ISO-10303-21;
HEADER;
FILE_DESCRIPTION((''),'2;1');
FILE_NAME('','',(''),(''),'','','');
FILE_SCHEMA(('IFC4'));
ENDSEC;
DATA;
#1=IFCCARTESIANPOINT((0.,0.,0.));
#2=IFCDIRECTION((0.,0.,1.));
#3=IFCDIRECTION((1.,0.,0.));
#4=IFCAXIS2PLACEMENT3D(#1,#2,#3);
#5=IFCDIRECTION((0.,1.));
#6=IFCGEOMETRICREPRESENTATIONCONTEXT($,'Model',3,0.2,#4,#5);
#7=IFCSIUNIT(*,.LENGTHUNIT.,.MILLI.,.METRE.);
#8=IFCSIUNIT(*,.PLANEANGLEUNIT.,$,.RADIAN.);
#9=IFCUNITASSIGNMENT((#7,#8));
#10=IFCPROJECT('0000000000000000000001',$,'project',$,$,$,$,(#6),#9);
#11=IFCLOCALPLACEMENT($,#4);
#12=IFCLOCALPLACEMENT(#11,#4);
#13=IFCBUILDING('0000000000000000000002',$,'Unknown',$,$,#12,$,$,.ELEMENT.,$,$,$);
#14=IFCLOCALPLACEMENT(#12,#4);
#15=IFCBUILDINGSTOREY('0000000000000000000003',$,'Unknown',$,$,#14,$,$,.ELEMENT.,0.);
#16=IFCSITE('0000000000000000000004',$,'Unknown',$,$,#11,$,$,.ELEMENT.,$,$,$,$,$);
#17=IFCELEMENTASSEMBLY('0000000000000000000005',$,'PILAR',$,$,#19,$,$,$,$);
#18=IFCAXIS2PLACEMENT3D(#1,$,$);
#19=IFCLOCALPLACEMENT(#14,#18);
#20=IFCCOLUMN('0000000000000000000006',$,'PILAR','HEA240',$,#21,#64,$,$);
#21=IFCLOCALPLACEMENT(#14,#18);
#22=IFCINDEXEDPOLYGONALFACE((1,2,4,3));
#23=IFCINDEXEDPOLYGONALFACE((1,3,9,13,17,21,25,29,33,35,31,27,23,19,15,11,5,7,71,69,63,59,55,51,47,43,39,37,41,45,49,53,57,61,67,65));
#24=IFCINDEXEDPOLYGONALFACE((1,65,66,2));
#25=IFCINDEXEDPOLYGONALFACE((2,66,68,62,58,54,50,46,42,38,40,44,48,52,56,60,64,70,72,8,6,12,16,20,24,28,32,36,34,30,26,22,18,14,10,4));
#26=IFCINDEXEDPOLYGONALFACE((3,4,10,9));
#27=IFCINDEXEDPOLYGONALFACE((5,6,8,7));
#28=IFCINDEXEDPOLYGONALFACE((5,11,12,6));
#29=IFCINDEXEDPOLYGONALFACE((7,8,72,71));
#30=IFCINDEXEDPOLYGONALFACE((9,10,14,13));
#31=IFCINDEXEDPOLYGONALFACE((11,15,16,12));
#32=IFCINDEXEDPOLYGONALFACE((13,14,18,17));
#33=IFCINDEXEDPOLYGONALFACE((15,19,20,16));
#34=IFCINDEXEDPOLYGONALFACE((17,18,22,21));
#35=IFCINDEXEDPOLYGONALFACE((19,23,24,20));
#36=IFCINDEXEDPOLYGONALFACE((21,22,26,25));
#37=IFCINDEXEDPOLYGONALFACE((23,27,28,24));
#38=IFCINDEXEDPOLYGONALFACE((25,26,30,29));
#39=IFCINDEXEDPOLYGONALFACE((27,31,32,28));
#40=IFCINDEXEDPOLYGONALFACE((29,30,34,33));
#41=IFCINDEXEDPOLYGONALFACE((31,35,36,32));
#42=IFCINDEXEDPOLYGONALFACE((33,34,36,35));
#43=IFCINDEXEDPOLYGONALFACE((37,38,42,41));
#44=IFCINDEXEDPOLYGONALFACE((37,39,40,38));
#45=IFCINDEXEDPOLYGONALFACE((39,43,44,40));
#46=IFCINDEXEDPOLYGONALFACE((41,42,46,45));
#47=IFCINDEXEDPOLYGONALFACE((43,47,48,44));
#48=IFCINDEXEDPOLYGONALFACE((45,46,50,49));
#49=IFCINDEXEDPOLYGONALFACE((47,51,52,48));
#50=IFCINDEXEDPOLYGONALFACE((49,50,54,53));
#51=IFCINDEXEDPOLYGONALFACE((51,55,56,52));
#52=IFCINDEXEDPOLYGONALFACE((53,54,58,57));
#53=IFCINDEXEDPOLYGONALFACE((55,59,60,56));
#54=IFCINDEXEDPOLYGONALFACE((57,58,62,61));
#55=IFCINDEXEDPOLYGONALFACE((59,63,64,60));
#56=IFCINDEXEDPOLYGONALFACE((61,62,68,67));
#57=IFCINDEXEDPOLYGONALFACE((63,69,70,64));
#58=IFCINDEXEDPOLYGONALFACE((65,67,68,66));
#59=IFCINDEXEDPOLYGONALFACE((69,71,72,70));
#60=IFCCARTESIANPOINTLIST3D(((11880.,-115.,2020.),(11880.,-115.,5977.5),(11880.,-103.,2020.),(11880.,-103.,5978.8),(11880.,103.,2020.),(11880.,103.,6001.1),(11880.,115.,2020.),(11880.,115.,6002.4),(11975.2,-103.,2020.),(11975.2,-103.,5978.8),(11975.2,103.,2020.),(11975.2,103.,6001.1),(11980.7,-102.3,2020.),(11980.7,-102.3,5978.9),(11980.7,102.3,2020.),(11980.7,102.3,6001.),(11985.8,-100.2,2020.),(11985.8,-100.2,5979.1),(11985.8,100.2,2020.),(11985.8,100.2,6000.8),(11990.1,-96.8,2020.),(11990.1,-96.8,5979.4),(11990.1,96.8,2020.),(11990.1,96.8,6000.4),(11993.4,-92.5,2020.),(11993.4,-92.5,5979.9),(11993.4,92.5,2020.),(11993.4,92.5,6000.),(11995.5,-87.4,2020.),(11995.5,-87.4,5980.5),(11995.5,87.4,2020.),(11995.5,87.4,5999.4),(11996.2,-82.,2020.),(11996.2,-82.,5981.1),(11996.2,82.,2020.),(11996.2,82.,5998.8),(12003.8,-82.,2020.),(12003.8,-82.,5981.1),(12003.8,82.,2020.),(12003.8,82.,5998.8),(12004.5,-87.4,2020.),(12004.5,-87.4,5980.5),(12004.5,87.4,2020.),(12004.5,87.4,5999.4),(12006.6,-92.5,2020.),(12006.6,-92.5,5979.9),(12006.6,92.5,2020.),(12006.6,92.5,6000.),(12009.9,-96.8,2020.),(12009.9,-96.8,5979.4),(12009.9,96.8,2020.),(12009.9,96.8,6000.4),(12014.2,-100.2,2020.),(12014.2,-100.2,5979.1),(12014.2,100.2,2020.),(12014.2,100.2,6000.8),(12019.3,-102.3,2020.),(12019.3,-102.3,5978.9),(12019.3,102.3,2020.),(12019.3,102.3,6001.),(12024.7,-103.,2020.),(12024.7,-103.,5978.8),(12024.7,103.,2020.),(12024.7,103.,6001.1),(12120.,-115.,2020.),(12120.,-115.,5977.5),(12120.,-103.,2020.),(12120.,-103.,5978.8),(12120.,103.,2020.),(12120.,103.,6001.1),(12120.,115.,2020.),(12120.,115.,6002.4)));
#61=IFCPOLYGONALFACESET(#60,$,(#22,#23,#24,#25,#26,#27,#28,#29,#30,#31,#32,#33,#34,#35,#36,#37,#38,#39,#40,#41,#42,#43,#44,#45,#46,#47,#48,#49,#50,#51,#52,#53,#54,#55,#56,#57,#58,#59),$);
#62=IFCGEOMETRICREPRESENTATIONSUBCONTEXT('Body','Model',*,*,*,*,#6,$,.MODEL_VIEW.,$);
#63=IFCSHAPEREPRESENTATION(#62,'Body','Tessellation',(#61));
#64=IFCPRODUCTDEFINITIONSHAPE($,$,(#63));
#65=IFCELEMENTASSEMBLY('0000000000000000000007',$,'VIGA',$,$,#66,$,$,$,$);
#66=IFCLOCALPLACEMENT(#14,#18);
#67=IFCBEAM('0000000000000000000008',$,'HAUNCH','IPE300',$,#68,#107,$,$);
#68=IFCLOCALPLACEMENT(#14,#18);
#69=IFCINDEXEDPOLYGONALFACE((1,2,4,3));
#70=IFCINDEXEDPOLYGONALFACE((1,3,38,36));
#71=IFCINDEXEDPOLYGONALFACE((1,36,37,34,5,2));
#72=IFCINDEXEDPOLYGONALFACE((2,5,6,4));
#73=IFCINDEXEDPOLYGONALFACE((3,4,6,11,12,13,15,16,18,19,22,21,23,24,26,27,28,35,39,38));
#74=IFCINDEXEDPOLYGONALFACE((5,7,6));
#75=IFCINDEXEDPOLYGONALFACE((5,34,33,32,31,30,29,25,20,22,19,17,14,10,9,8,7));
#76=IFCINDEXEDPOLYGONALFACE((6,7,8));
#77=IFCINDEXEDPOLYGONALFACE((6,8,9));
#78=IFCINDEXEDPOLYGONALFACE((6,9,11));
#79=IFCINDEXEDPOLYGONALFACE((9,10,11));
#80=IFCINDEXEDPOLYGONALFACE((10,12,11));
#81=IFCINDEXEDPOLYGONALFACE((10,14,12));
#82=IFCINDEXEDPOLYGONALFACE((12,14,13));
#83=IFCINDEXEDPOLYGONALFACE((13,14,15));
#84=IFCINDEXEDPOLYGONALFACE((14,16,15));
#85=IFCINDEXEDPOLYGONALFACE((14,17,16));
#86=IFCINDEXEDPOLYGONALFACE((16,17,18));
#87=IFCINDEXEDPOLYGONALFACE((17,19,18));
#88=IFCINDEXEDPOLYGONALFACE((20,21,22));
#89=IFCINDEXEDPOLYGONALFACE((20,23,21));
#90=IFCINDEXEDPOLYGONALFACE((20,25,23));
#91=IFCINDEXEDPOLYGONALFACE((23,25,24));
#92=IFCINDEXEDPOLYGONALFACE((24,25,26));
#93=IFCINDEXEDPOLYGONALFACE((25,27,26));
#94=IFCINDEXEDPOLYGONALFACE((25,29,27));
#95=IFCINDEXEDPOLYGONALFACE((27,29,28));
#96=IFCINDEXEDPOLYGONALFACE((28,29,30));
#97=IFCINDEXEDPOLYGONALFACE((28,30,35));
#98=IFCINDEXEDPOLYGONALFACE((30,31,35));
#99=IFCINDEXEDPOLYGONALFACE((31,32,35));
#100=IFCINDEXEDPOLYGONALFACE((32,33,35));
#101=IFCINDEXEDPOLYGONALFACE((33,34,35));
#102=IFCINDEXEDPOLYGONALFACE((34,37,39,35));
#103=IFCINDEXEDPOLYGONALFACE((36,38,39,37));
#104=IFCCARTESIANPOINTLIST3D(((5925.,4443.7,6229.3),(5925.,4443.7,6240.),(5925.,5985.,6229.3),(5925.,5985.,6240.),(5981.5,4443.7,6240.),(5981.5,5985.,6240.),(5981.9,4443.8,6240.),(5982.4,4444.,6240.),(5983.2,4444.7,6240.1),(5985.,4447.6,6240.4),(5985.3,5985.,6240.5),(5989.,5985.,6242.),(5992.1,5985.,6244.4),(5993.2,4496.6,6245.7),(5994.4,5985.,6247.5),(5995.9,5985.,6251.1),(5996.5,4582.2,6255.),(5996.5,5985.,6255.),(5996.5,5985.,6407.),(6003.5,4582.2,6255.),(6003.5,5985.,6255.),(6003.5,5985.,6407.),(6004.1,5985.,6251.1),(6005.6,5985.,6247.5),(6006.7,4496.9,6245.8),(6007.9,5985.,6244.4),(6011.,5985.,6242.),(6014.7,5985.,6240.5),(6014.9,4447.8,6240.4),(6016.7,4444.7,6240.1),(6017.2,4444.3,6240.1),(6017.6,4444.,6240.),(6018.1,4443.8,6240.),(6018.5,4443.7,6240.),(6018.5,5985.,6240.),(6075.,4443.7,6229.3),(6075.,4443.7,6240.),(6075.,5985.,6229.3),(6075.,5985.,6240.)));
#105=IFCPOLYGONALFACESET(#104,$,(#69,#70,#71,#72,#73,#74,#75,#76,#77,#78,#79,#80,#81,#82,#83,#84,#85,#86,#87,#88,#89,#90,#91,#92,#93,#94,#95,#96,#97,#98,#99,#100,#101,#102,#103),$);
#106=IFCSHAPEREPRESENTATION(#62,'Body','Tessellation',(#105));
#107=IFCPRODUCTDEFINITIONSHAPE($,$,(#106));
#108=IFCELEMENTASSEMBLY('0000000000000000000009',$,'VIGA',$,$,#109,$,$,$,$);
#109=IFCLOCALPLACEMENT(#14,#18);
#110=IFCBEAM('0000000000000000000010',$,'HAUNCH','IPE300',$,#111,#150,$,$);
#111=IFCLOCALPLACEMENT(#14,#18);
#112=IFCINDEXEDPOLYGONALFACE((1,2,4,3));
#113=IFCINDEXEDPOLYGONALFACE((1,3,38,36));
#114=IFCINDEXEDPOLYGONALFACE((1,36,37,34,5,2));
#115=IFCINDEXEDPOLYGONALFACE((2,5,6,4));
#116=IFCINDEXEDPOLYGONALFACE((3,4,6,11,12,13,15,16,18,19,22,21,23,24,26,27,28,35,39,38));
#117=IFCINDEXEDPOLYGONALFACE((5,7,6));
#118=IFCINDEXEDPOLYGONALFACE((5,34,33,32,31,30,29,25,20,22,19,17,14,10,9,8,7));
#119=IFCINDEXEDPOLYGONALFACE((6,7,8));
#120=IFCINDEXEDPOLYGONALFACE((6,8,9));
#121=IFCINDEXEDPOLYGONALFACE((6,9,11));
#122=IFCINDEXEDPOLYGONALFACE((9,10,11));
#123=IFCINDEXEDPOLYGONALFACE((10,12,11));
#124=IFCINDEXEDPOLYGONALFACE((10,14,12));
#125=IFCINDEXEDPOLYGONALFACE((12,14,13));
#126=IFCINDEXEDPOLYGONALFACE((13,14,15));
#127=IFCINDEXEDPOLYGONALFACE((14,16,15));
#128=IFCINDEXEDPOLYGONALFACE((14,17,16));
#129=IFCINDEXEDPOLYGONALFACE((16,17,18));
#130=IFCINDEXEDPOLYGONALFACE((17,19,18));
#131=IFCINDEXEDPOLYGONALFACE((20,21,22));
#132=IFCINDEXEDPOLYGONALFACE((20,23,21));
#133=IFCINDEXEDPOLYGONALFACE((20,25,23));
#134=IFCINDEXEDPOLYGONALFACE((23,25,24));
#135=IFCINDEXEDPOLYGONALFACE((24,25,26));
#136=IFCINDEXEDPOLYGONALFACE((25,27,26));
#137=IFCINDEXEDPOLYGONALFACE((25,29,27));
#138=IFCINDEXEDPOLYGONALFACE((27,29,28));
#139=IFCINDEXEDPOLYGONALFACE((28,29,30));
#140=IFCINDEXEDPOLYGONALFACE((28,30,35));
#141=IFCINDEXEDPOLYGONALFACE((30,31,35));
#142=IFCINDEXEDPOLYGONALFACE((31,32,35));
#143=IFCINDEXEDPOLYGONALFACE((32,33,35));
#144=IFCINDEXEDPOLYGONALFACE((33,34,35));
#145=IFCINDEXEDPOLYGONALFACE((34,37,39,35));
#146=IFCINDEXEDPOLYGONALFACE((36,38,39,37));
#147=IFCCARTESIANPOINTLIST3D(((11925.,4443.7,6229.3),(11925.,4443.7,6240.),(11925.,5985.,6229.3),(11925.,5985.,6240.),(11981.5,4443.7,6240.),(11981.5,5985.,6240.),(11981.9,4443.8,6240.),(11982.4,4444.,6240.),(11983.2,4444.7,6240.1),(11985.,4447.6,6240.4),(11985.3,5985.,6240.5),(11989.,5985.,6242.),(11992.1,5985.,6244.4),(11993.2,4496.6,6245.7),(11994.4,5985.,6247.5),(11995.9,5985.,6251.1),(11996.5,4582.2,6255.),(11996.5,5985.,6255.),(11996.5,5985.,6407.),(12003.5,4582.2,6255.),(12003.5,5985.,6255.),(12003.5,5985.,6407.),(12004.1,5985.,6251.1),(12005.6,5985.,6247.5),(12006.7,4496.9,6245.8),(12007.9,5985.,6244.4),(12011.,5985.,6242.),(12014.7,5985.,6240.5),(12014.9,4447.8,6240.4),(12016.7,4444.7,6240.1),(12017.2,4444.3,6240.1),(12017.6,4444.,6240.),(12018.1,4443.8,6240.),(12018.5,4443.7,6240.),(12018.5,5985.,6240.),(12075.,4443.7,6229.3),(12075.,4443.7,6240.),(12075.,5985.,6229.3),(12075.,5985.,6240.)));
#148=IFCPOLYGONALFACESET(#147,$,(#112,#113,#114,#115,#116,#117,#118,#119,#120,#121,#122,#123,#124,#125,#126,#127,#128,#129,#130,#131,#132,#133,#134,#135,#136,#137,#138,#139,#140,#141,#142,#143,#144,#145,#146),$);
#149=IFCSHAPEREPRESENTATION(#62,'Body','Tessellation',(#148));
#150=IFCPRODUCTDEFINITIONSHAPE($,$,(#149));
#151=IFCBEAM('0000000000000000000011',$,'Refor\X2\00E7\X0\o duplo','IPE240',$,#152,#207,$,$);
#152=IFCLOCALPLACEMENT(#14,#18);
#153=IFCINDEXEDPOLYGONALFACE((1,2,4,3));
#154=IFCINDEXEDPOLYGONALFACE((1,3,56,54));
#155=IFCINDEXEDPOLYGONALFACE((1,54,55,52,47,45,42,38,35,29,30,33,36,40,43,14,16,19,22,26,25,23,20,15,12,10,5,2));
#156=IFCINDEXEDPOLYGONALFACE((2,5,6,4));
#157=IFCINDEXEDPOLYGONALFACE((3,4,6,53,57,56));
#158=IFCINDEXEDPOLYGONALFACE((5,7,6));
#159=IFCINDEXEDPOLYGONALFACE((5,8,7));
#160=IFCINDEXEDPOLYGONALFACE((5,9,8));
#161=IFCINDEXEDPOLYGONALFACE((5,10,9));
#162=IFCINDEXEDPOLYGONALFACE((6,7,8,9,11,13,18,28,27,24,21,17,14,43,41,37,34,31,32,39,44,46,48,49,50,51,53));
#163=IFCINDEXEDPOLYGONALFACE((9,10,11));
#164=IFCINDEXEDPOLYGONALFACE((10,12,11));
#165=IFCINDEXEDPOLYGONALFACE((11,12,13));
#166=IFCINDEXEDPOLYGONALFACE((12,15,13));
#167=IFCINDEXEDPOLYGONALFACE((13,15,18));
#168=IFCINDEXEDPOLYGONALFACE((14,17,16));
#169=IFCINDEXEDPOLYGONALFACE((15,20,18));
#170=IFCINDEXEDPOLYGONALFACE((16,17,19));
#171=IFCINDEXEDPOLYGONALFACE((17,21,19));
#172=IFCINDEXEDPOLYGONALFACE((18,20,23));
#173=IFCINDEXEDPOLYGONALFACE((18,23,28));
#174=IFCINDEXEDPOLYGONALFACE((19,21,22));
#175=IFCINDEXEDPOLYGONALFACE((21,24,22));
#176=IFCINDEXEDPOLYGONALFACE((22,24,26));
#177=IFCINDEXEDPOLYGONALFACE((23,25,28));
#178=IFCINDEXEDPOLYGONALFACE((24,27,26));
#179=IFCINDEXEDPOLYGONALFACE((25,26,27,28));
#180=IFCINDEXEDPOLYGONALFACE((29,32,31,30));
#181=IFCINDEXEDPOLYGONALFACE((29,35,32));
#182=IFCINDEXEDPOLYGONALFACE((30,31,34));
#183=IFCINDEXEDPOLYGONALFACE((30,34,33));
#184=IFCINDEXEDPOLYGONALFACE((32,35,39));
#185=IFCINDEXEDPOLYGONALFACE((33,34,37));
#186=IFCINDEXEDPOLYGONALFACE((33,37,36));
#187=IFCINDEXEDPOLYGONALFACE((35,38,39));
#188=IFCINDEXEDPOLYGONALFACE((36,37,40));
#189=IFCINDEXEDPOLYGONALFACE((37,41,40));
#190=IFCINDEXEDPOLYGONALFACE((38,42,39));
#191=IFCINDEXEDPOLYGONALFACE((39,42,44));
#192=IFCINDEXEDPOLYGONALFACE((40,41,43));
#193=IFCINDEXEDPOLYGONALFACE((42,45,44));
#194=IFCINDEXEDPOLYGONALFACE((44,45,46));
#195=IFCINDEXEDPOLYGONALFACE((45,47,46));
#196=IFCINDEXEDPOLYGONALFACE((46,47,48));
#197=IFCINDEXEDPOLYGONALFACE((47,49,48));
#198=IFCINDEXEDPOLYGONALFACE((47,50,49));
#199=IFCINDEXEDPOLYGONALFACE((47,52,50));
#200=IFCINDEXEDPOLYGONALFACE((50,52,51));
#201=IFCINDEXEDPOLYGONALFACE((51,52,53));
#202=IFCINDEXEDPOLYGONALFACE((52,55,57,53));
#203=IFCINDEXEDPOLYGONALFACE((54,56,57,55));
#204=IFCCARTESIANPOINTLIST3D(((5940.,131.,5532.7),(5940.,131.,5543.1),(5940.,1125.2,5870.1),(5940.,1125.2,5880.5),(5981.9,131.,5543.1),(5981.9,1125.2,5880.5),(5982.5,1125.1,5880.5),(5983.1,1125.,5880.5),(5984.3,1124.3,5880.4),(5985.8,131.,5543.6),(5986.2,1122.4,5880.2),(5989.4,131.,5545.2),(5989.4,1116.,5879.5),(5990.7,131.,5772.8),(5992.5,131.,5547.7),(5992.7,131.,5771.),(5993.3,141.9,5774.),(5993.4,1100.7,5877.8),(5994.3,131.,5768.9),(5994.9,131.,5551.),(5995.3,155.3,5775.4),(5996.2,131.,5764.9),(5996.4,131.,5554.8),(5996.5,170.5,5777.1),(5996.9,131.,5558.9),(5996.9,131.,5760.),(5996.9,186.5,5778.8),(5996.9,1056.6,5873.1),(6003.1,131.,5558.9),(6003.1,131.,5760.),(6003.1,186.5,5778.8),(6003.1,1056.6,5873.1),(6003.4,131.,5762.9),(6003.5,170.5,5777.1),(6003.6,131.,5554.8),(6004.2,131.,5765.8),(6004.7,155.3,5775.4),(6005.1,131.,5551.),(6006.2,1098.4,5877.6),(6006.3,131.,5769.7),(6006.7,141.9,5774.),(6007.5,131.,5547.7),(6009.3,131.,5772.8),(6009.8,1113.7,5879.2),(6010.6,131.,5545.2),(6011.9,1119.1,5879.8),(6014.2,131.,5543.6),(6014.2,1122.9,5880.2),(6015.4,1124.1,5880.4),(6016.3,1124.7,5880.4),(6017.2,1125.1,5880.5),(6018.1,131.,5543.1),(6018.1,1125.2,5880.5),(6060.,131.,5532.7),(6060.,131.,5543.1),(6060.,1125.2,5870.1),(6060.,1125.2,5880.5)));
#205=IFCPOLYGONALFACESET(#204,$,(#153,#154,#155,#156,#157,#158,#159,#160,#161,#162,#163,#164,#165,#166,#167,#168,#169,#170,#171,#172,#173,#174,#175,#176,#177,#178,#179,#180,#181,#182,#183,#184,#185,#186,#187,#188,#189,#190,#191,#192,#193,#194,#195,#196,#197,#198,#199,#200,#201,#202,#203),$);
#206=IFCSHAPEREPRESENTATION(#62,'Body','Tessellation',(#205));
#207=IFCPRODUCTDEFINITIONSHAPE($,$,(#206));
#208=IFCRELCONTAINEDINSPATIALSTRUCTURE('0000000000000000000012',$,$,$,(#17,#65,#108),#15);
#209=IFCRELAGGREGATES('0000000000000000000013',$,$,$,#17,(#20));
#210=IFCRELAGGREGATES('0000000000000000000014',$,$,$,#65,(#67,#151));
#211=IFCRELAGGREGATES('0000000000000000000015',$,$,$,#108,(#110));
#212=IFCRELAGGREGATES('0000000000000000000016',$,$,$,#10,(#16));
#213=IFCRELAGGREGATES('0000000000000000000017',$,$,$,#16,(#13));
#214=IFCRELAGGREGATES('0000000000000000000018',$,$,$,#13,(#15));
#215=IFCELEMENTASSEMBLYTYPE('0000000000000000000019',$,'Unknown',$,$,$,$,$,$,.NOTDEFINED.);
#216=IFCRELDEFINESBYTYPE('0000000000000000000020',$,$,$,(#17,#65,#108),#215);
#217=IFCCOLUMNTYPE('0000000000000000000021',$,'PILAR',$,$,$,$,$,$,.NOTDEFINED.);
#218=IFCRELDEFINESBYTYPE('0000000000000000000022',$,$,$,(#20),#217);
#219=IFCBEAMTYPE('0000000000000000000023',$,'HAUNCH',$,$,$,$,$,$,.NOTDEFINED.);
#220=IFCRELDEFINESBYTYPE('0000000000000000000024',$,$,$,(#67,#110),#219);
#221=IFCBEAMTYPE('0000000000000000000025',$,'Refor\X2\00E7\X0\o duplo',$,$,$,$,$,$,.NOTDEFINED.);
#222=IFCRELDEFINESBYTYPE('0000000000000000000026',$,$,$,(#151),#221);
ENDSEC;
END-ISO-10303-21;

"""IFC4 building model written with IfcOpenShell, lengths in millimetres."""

from ifc_helpers import new_model, si_unit, direction, frame, origin_with_axes, origin_2d_with_axis, place, context, subcontext, project, spatial, i_section, extrude, clip, halfspace, type_object, element, aggregate, save


model = new_model("IFC4")

# Units and contexts
model_context = context("Model", 3, precision=0.2, world=origin_with_axes(), true_north=direction((0.0, 1.0)))
body_context = subcontext(model_context, "Body", "Model", "MODEL_VIEW")
ifc_project = project(units=[si_unit("LENGTHUNIT", "METRE", prefix="MILLI"), si_unit("PLANEANGLEUNIT", "RADIAN")], contexts=[model_context])

# Site, building, storey
site_placement = place(None, origin_with_axes())
site = spatial("IfcSite", under=ifc_project, at=site_placement, Name="Unknown", CompositionType="ELEMENT")
building_placement = place(site_placement, origin_with_axes())
building = spatial("IfcBuilding", under=site, at=building_placement, Name="Unknown", CompositionType="ELEMENT")
storey_placement = place(building_placement, origin_with_axes())
storey = spatial("IfcBuildingStorey", under=building, at=storey_placement, Name="Unknown", CompositionType="ELEMENT", Elevation=0.0)

# Element assembly, column
element_assembly_type = type_object("IfcElementAssemblyType", Name="Unknown", PredefinedType="NOTDEFINED")
assembly_1_placement = place(storey_placement, frame((12000.0, 0.0, 2000.0), z_axis=(1.0, 0.0, 0.0), x_axis=(0.0, 0.0, 1.0)))
assembly_1 = element("IfcElementAssembly", 1, at=assembly_1_placement, inside=storey, type_object=element_assembly_type, Name="PILAR")
column_type = type_object("IfcColumnType", Name="PILAR", PredefinedType="NOTDEFINED")
column_placement = place(assembly_1_placement, origin_with_axes())
column = element("IfcColumn", 2, at=column_placement, type_object=column_type, Name="PILAR", Description="HEA240", context=body_context, shape_type="Clipping", body=[
    clip(clip(extrude(i_section(OverallWidth=240.0, OverallDepth=230.0, WebThickness=7.5, FlangeThickness=12.0, FilletRadius=21.0, FlangeEdgeRadius=0.0, FlangeSlope=0.0, at=origin_2d_with_axis()), frame((-220.0, 0.0, 0.0), z_axis=(-1.0, 0.0, 0.0), x_axis=(0.0, 0.0, 1.0)), (0.0, 0.0, -1.0), 4449.9), halfspace(frame((20.0, -115.0, 0.0), z_axis=(1.0, 0.0, 0.0), x_axis=(0.0, 1.0, 0.0)), True)), halfspace(frame((3977.5, 115.0, 0.0), z_axis=(-0.994183, -0.107703, 0.0), x_axis=(0.107703, -0.994183, 0.0)), True)),
])

# Element assemblies, beams
assembly_2_placement = place(storey_placement, frame((6000.0, 12.9, 5880.7), z_axis=(1.0, 0.0, 0.0), x_axis=(0.0, 0.994183, 0.107703)))
assembly_2 = element("IfcElementAssembly", 3, at=assembly_2_placement, inside=storey, type_object=element_assembly_type, Name="VIGA")
beam_type_1 = type_object("IfcBeamType", Name="HAUNCH", PredefinedType="NOTDEFINED")
beam_1_placement = place(assembly_2_placement, frame((5991.0, -147.5, 0.0), z_axis=(0.0, 0.0, -1.0), x_axis=(-0.994183, 0.107703, 0.0)))
beam_1 = element("IfcBeam", 4, at=beam_1_placement, type_object=beam_type_1, Name="HAUNCH", Description="IPE300", context=body_context, shape_type="Clipping", body=[
    clip(clip(clip(extrude(i_section(OverallWidth=150.0, OverallDepth=300.0, WebThickness=7.1, FlangeThickness=10.7, FilletRadius=15.0, FlangeEdgeRadius=0.0, FlangeSlope=0.0, at=origin_2d_with_axis()), frame((-300.0, 0.0, 0.0), z_axis=(-1.0, 0.0, 0.0), x_axis=(0.0, 0.0, 1.0)), (0.0, 0.0, -1.0), 2141.3), halfspace(frame((0.0, 27.7, 0.0), z_axis=(-1.0, 0.0, 0.0), x_axis=(0.0, -1.0, 0.0)), False)), halfspace(frame((-1129.2, 150.0, -75.0), z_axis=(0.107703, 0.994183, 0.0), x_axis=(0.0, 0.0, 1.0)), False)), halfspace(frame((1541.3, -139.3, 0.0), z_axis=(-1.0, 0.0, 0.0), x_axis=(0.0, -1.0, 0.0)), True)),
])
assembly_3_placement = place(storey_placement, frame((12000.0, 12.9, 5880.7), z_axis=(1.0, 0.0, 0.0), x_axis=(0.0, 0.994183, 0.107703)))
assembly_3 = element("IfcElementAssembly", 5, at=assembly_3_placement, inside=storey, type_object=element_assembly_type, Name="VIGA")
beam_2_placement = place(assembly_3_placement, frame((5991.0, -147.5, 0.0), z_axis=(0.0, 0.0, -1.0), x_axis=(-0.994183, 0.107703, 0.0)))
beam_2 = element("IfcBeam", 6, at=beam_2_placement, type_object=beam_type_1, Name="HAUNCH", Description="IPE300", context=body_context, shape_type="Clipping", body=[
    clip(clip(clip(extrude(i_section(OverallWidth=150.0, OverallDepth=300.0, WebThickness=7.1, FlangeThickness=10.7, FilletRadius=15.0, FlangeEdgeRadius=0.0, FlangeSlope=0.0, at=origin_2d_with_axis()), frame((-300.0, 0.0, 0.0), z_axis=(-1.0, 0.0, 0.0), x_axis=(0.0, 0.0, 1.0)), (0.0, 0.0, -1.0), 2141.3), halfspace(frame((0.0, 27.7, 0.0), z_axis=(-1.0, 0.0, 0.0), x_axis=(0.0, -1.0, 0.0)), False)), halfspace(frame((-1129.2, 150.0, -75.0), z_axis=(0.107703, 0.994183, 0.0), x_axis=(0.0, 0.0, 1.0)), False)), halfspace(frame((1541.3, -139.3, 0.0), z_axis=(-1.0, 0.0, 0.0), x_axis=(0.0, -1.0, 0.0)), True)),
])

# Beam
beam_type_2 = type_object("IfcBeamType", Name="Reforço duplo", PredefinedType="NOTDEFINED")
beam_3_placement = place(assembly_2_placement, frame((53.8, -241.6, 0.0), z_axis=(0.0, 0.0, 1.0), x_axis=(0.976051, 0.217543, 0.0)))
beam_3 = element("IfcBeam", 7, at=beam_3_placement, type_object=beam_type_2, Name="Reforço duplo", Description="IPE240", context=body_context, shape_type="Clipping", body=[
    clip(clip(clip(extrude(i_section(OverallWidth=120.0, OverallDepth=240.0, WebThickness=6.2, FlangeThickness=9.8, FilletRadius=15.0, FlangeEdgeRadius=0.0, FlangeSlope=0.0, at=origin_2d_with_axis()), frame((-199.3, 0.0, 0.0), z_axis=(-1.0, 0.0, 0.0), x_axis=(0.0, 0.0, 1.0)), (0.0, 0.0, -1.0), 1529.9), halfspace(frame((476.2, 1282.9, 0.0), z_axis=(-0.946943, 0.321401, 0.0), x_axis=(-0.321401, -0.946943, 0.0)), False)), halfspace(frame((20.4, 120.0, -60.0), z_axis=(0.217543, 0.976051, 0.0), x_axis=(0.0, 0.0, 1.0)), False)), halfspace(frame((1049.9, -120.0, 0.0), z_axis=(0.946943, -0.321401, 0.0), x_axis=(0.321401, 0.946943, 0.0)), False)),
])

aggregate(assembly_1, [column])
aggregate(assembly_2, [beam_1, beam_3])
aggregate(assembly_3, [beam_2])

save(model, "model.ifc")
